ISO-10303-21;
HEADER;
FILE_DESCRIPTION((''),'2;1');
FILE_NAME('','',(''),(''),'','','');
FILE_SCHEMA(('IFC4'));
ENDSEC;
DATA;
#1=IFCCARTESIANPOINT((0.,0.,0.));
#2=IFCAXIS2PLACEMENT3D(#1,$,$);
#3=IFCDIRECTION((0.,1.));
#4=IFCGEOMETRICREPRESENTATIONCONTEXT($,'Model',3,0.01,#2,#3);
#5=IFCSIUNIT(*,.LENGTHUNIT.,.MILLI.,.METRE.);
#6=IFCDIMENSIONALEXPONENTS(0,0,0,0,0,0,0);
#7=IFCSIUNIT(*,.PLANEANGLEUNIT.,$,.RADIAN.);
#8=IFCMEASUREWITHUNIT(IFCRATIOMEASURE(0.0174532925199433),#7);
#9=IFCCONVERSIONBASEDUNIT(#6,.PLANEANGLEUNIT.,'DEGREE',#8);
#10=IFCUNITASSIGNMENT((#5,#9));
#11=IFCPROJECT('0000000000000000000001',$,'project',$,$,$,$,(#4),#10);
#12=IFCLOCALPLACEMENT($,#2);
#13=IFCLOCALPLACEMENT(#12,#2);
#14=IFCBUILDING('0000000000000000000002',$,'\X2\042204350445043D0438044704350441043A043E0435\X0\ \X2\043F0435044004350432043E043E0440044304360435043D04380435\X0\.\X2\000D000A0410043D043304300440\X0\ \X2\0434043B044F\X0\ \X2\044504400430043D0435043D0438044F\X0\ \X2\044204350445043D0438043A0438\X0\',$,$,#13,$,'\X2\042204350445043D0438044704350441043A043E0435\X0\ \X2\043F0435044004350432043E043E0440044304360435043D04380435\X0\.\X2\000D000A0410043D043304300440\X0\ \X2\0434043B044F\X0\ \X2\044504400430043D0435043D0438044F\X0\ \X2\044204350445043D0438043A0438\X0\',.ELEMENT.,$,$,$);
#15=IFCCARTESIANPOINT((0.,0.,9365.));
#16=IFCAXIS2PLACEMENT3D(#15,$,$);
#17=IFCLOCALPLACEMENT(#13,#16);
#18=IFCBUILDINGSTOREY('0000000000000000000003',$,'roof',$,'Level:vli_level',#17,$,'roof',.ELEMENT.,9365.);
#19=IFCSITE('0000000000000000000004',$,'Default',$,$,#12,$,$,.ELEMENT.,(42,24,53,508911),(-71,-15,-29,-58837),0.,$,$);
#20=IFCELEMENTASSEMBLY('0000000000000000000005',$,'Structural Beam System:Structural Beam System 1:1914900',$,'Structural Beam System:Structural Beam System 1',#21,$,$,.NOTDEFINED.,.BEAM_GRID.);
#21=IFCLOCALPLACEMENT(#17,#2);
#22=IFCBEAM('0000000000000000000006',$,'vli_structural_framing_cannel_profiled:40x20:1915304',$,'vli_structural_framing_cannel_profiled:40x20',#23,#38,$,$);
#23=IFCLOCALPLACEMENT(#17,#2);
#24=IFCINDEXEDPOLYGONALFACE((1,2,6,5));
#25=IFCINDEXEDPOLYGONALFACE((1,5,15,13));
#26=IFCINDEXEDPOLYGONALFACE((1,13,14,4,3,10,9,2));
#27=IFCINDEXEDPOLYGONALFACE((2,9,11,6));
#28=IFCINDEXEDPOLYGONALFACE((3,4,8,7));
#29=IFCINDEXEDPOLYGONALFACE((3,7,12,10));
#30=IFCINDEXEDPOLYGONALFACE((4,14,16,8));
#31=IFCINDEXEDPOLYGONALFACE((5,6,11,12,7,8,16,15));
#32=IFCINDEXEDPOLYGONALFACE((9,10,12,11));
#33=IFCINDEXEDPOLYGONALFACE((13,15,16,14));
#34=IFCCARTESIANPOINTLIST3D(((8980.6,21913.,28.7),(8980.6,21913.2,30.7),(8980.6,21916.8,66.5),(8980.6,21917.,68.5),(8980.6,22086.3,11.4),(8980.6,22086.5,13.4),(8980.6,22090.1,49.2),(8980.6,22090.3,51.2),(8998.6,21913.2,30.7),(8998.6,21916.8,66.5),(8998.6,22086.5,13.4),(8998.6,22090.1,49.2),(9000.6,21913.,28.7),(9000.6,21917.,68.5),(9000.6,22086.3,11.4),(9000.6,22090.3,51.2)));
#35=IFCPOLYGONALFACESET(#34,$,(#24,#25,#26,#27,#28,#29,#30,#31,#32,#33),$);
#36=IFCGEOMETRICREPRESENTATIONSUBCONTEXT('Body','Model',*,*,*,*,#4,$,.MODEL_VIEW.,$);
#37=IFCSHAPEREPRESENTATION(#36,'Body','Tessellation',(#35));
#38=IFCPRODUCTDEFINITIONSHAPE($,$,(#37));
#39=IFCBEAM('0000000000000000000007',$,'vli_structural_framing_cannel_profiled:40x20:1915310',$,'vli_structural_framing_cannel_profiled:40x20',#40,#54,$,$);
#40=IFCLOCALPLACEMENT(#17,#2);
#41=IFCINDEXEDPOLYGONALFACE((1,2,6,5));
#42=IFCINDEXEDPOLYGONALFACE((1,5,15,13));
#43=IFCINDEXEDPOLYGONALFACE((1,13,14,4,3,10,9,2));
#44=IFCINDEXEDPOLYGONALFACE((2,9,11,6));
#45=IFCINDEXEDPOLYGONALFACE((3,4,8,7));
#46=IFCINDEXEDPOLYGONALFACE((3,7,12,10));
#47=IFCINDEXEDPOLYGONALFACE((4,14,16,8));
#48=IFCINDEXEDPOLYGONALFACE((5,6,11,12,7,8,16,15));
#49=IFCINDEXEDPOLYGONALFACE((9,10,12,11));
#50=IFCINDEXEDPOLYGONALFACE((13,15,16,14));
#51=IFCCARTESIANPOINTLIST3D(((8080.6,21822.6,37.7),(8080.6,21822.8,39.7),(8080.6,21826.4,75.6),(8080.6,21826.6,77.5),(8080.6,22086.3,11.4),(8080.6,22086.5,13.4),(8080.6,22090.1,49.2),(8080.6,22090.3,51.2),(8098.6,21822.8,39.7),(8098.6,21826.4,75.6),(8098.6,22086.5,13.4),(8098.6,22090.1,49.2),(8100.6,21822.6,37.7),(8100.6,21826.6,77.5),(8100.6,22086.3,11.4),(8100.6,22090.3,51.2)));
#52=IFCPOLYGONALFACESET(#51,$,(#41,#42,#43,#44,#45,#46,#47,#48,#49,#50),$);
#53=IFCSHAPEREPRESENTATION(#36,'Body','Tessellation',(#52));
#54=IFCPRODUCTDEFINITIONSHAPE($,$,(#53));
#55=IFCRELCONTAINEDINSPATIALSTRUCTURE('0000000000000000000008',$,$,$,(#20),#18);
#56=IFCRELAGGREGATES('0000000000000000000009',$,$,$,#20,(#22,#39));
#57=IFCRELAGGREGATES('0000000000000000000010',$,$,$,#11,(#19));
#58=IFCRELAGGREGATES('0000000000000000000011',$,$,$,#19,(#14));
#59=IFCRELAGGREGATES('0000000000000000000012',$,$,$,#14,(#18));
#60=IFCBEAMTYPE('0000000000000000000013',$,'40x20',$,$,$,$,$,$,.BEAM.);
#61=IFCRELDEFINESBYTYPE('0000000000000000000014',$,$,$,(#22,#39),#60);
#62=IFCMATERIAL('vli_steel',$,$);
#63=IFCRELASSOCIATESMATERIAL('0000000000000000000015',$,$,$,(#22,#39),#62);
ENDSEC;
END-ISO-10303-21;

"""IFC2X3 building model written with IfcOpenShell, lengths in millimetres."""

from ifc_helpers import new_model, entity, si_unit, converted_unit, direction, frame, origin, place, context, subcontext, project, spatial, polyline, outline, extrude, material, type_object, element, aggregate, save


model = new_model("IFC2X3")

# Units and contexts
model_context = context("Model", 3, precision=0.01, world=origin(), true_north=direction((0.0, 1.0)))
body_context = subcontext(model_context, "Body", "Model", "MODEL_VIEW")
ifc_project = project(units=[si_unit("LENGTHUNIT", "METRE", prefix="MILLI"), converted_unit("PLANEANGLEUNIT", "DEGREE", entity("IfcRatioMeasure", 0.0174532925199433), si_unit("PLANEANGLEUNIT", "RADIAN"), dimensions=[0, 0, 0, 0, 0, 0, 0])], contexts=[model_context])

# Site, building, storey
site_placement = place(None, origin())
site = spatial("IfcSite", under=ifc_project, at=site_placement, Name="Default", CompositionType="ELEMENT", RefLatitude=(42, 24, 53, 508911), RefLongitude=(-71, -15, -29, -58837), RefElevation=0.0)
building_placement = place(site_placement, origin())
building = spatial("IfcBuilding", under=site, at=building_placement, Name="Техническое перевооружение.\r\nАнгар для хранения техники", LongName="Техническое перевооружение.\r\nАнгар для хранения техники", CompositionType="ELEMENT")
storey_placement = place(building_placement, frame((0.0, 0.0, 9365.0)))
storey = spatial("IfcBuildingStorey", under=building, at=storey_placement, Name="roof", ObjectType="Level:vli_level", LongName="roof", CompositionType="ELEMENT", Elevation=9365.0)

# Element assembly, beams
assembly_placement = place(storey_placement, origin())
assembly = element("IfcElementAssembly", 1, at=assembly_placement, inside=storey, Name="Structural Beam System:Structural Beam System 1:1914900", ObjectType="Structural Beam System:Structural Beam System 1", AssemblyPlace="NOTDEFINED", PredefinedType="BEAM_GRID")
ifc_material = material(Name="vli_steel")
beam_type = type_object("IfcBeamType", Name="40x20", PredefinedType="BEAM")
beam_1_placement = place(assembly_placement, frame((9000.0, 22090.8, 10.9), z_axis=(0.0, 0.099504, 0.995037), x_axis=(0.0, -0.995037, 0.099504)))
beam_1 = element("IfcBeam", 2, at=beam_1_placement, type_object=beam_type, material=ifc_material, Name="vli_structural_framing_cannel_profiled:40x20:1915304", ObjectType="vli_structural_framing_cannel_profiled:40x20", context=body_context, shape_type="SweptSolid", body=[
    extrude(outline(polyline([(-20.0, -9.5), (-18.0, -9.5), (-18.0, 8.5), (18.0, 8.5), (18.0, -9.5), (20.0, -9.5), (20.0, 10.5), (-20.0, 10.5), (-20.0, -9.5)])), frame((4.6, -9.9, 20.0), z_axis=(1.0, 0.0, 0.0), x_axis=(0.0, 0.0, -1.0)), (0.0, 0.0, 1.0), 174.1),
])
beam_2_placement = place(assembly_placement, frame((8100.0, 22090.8, 10.9), z_axis=(0.0, 0.099504, 0.995037), x_axis=(0.0, -0.995037, 0.099504)))
beam_2 = element("IfcBeam", 3, at=beam_2_placement, type_object=beam_type, material=ifc_material, Name="vli_structural_framing_cannel_profiled:40x20:1915310", ObjectType="vli_structural_framing_cannel_profiled:40x20", context=body_context, shape_type="SweptSolid", body=[
    extrude(outline(polyline([(-20.0, -9.5), (-18.0, -9.5), (-18.0, 8.5), (18.0, 8.5), (18.0, -9.5), (20.0, -9.5), (20.0, 10.5), (-20.0, 10.5), (-20.0, -9.5)])), frame((4.6, -9.9, 20.0), z_axis=(1.0, 0.0, 0.0), x_axis=(0.0, 0.0, -1.0)), (0.0, 0.0, 1.0), 265.0),
])
aggregate(assembly, [beam_1, beam_2])

save(model, "model.ifc")
